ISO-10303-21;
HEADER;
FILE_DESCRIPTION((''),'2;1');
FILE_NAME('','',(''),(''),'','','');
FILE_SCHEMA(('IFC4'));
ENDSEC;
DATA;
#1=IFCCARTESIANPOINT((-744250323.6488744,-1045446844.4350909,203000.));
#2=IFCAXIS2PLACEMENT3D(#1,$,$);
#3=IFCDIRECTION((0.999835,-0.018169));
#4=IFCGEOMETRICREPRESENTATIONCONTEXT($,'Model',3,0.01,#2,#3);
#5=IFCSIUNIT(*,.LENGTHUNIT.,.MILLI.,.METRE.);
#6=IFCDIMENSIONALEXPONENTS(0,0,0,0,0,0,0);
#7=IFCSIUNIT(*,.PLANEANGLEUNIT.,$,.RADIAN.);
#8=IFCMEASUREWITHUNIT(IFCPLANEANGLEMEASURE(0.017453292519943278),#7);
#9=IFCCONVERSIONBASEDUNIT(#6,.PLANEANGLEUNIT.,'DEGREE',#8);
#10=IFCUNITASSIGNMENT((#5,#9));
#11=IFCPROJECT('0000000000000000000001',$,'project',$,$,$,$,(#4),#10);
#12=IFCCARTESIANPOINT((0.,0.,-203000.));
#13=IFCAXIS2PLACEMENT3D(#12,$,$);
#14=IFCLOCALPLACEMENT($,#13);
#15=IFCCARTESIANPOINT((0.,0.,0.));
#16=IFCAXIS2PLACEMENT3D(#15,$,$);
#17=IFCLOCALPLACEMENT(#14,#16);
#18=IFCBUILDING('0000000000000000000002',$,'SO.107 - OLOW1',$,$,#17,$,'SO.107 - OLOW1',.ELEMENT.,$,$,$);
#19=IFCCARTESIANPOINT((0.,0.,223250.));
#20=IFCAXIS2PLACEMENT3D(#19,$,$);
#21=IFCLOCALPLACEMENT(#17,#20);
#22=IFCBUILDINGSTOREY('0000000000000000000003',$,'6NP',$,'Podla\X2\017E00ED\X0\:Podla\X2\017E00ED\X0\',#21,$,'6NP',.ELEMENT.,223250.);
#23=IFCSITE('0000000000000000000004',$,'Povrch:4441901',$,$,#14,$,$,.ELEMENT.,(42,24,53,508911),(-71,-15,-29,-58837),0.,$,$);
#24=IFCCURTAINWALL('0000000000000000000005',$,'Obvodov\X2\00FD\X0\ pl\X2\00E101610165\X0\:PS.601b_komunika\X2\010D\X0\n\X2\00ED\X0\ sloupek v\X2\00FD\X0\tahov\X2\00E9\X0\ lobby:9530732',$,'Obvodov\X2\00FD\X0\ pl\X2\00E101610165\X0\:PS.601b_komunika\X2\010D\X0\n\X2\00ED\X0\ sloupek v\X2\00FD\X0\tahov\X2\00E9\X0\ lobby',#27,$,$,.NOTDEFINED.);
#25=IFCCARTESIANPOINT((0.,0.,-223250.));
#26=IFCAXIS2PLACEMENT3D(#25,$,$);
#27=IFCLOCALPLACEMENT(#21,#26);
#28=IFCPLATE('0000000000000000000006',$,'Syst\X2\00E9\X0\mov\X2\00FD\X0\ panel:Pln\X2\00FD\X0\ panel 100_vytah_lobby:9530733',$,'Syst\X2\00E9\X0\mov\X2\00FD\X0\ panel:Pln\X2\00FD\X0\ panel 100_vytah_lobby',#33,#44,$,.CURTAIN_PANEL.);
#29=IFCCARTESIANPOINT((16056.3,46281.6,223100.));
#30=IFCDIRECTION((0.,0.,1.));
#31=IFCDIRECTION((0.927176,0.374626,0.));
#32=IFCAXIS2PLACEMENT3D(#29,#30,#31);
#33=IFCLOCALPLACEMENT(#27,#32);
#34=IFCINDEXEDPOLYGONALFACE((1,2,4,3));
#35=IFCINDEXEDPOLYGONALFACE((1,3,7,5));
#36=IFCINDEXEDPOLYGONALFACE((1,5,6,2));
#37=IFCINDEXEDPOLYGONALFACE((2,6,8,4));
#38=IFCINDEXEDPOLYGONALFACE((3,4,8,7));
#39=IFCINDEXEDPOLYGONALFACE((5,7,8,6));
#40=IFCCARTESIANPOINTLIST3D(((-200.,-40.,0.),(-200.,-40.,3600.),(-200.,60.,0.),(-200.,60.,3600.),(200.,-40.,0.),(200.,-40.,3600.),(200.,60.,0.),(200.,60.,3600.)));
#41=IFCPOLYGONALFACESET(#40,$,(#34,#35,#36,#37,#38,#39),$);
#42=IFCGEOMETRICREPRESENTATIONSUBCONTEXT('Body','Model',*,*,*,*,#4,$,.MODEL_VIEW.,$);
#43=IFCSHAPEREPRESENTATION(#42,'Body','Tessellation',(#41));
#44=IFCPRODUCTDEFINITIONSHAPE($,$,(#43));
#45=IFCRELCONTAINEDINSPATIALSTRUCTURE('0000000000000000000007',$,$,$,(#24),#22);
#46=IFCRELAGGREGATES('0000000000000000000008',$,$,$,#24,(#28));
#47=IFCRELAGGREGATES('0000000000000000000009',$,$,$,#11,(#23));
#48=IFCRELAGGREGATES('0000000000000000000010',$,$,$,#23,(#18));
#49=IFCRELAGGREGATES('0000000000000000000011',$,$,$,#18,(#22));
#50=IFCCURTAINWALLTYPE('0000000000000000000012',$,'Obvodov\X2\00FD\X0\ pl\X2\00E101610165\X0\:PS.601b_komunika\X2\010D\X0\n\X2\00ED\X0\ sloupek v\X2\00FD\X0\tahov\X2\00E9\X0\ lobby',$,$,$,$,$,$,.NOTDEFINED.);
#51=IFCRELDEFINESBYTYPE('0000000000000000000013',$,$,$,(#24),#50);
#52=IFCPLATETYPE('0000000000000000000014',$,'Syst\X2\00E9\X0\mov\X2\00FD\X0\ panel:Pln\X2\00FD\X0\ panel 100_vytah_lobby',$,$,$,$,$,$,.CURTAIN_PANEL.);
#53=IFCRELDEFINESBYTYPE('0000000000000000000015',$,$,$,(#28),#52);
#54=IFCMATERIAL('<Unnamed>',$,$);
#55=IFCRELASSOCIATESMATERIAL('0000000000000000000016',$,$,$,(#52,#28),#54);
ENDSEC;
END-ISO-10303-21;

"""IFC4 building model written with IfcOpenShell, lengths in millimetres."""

from ifc_helpers import new_model, entity, si_unit, converted_unit, direction, frame, origin, place, context, subcontext, project, spatial, indexed_curve, outline, extrude, source, transform, mapped, material, type_object, type_shapes, element, aggregate, save


model = new_model("IFC4")

# Units and contexts
model_context = context("Model", 3, precision=0.01, world=frame((-744250323.6488744, -1045446844.4350909, 203000.0)), true_north=direction((0.999835, -0.018169)))
body_context = subcontext(model_context, "Body", "Model", "MODEL_VIEW")
ifc_project = project(units=[si_unit("LENGTHUNIT", "METRE", prefix="MILLI"), converted_unit("PLANEANGLEUNIT", "DEGREE", entity("IfcPlaneAngleMeasure", 0.017453292519943278), si_unit("PLANEANGLEUNIT", "RADIAN"), dimensions=[0, 0, 0, 0, 0, 0, 0])], contexts=[model_context])

# Site, building, storey
site_placement = place(None, frame((0.0, 0.0, -203000.0)))
site = spatial("IfcSite", under=ifc_project, at=site_placement, Name="Povrch:4441901", CompositionType="ELEMENT", RefLatitude=(42, 24, 53, 508911), RefLongitude=(-71, -15, -29, -58837), RefElevation=0.0)
building_placement = place(site_placement, origin())
building = spatial("IfcBuilding", under=site, at=building_placement, Name="SO.107 - OLOW1", LongName="SO.107 - OLOW1", CompositionType="ELEMENT")
storey_placement = place(building_placement, frame((0.0, 0.0, 223250.0)))
storey = spatial("IfcBuildingStorey", under=building, at=storey_placement, Name="6NP", ObjectType="Podlaží:Podlaží", LongName="6NP", CompositionType="ELEMENT", Elevation=223250.0)

# Shared definitions
ifc_material_1 = material(Name="<Unnamed>")

# Curtain wall, plate
curtain_wall_type_1 = type_object("IfcCurtainWallType", Name="Obvodový plášť:PS.601b_komunikační sloupek výtahové lobby", PredefinedType="NOTDEFINED")
curtain_wall_1_placement = place(storey_placement, frame((0.0, 0.0, -223250.0)))
curtain_wall_1 = element("IfcCurtainWall", 1, at=curtain_wall_1_placement, inside=storey, type_object=curtain_wall_type_1, Name="Obvodový plášť:PS.601b_komunikační sloupek výtahové lobby:9530732", ObjectType="Obvodový plášť:PS.601b_komunikační sloupek výtahové lobby", PredefinedType="NOTDEFINED")
plate_type_1 = type_object("IfcPlateType", Name="Systémový panel:Plný panel 100_vytah_lobby", PredefinedType="CURTAIN_PANEL", material=ifc_material_1)
shared_shape_1 = source(origin(), body_context, "Body", "SweptSolid", [
    extrude(outline(indexed_curve([(-50.0, -200.0), (50.0, -200.0), (50.0, 200.0), (-50.0, 200.0), (-50.0, -200.0)], self_intersect=False)), frame((0.0, 10.0, 0.0), z_axis=(0.0, 0.0, 1.0), x_axis=(0.0, 1.0, 0.0)), (0.0, 0.0, 1.0), 3600.0),
])
type_shapes(plate_type_1, [shared_shape_1])
plate_1_placement = place(curtain_wall_1_placement, frame((16056.3, 46281.6, 223100.0), z_axis=(0.0, 0.0, 1.0), x_axis=(0.927176, 0.374626, 0.0)))
plate_1 = element("IfcPlate", 2, at=plate_1_placement, type_object=plate_type_1, material=ifc_material_1, Name="Systémový panel:Plný panel 100_vytah_lobby:9530733", ObjectType="Systémový panel:Plný panel 100_vytah_lobby", PredefinedType="CURTAIN_PANEL", context=body_context, shape_type="MappedRepresentation", body=[
    mapped(shared_shape_1, transform((0.0, 0.0, 0.0), scale=1.0)),
])
aggregate(curtain_wall_1, [plate_1])

save(model, "model.ifc")
